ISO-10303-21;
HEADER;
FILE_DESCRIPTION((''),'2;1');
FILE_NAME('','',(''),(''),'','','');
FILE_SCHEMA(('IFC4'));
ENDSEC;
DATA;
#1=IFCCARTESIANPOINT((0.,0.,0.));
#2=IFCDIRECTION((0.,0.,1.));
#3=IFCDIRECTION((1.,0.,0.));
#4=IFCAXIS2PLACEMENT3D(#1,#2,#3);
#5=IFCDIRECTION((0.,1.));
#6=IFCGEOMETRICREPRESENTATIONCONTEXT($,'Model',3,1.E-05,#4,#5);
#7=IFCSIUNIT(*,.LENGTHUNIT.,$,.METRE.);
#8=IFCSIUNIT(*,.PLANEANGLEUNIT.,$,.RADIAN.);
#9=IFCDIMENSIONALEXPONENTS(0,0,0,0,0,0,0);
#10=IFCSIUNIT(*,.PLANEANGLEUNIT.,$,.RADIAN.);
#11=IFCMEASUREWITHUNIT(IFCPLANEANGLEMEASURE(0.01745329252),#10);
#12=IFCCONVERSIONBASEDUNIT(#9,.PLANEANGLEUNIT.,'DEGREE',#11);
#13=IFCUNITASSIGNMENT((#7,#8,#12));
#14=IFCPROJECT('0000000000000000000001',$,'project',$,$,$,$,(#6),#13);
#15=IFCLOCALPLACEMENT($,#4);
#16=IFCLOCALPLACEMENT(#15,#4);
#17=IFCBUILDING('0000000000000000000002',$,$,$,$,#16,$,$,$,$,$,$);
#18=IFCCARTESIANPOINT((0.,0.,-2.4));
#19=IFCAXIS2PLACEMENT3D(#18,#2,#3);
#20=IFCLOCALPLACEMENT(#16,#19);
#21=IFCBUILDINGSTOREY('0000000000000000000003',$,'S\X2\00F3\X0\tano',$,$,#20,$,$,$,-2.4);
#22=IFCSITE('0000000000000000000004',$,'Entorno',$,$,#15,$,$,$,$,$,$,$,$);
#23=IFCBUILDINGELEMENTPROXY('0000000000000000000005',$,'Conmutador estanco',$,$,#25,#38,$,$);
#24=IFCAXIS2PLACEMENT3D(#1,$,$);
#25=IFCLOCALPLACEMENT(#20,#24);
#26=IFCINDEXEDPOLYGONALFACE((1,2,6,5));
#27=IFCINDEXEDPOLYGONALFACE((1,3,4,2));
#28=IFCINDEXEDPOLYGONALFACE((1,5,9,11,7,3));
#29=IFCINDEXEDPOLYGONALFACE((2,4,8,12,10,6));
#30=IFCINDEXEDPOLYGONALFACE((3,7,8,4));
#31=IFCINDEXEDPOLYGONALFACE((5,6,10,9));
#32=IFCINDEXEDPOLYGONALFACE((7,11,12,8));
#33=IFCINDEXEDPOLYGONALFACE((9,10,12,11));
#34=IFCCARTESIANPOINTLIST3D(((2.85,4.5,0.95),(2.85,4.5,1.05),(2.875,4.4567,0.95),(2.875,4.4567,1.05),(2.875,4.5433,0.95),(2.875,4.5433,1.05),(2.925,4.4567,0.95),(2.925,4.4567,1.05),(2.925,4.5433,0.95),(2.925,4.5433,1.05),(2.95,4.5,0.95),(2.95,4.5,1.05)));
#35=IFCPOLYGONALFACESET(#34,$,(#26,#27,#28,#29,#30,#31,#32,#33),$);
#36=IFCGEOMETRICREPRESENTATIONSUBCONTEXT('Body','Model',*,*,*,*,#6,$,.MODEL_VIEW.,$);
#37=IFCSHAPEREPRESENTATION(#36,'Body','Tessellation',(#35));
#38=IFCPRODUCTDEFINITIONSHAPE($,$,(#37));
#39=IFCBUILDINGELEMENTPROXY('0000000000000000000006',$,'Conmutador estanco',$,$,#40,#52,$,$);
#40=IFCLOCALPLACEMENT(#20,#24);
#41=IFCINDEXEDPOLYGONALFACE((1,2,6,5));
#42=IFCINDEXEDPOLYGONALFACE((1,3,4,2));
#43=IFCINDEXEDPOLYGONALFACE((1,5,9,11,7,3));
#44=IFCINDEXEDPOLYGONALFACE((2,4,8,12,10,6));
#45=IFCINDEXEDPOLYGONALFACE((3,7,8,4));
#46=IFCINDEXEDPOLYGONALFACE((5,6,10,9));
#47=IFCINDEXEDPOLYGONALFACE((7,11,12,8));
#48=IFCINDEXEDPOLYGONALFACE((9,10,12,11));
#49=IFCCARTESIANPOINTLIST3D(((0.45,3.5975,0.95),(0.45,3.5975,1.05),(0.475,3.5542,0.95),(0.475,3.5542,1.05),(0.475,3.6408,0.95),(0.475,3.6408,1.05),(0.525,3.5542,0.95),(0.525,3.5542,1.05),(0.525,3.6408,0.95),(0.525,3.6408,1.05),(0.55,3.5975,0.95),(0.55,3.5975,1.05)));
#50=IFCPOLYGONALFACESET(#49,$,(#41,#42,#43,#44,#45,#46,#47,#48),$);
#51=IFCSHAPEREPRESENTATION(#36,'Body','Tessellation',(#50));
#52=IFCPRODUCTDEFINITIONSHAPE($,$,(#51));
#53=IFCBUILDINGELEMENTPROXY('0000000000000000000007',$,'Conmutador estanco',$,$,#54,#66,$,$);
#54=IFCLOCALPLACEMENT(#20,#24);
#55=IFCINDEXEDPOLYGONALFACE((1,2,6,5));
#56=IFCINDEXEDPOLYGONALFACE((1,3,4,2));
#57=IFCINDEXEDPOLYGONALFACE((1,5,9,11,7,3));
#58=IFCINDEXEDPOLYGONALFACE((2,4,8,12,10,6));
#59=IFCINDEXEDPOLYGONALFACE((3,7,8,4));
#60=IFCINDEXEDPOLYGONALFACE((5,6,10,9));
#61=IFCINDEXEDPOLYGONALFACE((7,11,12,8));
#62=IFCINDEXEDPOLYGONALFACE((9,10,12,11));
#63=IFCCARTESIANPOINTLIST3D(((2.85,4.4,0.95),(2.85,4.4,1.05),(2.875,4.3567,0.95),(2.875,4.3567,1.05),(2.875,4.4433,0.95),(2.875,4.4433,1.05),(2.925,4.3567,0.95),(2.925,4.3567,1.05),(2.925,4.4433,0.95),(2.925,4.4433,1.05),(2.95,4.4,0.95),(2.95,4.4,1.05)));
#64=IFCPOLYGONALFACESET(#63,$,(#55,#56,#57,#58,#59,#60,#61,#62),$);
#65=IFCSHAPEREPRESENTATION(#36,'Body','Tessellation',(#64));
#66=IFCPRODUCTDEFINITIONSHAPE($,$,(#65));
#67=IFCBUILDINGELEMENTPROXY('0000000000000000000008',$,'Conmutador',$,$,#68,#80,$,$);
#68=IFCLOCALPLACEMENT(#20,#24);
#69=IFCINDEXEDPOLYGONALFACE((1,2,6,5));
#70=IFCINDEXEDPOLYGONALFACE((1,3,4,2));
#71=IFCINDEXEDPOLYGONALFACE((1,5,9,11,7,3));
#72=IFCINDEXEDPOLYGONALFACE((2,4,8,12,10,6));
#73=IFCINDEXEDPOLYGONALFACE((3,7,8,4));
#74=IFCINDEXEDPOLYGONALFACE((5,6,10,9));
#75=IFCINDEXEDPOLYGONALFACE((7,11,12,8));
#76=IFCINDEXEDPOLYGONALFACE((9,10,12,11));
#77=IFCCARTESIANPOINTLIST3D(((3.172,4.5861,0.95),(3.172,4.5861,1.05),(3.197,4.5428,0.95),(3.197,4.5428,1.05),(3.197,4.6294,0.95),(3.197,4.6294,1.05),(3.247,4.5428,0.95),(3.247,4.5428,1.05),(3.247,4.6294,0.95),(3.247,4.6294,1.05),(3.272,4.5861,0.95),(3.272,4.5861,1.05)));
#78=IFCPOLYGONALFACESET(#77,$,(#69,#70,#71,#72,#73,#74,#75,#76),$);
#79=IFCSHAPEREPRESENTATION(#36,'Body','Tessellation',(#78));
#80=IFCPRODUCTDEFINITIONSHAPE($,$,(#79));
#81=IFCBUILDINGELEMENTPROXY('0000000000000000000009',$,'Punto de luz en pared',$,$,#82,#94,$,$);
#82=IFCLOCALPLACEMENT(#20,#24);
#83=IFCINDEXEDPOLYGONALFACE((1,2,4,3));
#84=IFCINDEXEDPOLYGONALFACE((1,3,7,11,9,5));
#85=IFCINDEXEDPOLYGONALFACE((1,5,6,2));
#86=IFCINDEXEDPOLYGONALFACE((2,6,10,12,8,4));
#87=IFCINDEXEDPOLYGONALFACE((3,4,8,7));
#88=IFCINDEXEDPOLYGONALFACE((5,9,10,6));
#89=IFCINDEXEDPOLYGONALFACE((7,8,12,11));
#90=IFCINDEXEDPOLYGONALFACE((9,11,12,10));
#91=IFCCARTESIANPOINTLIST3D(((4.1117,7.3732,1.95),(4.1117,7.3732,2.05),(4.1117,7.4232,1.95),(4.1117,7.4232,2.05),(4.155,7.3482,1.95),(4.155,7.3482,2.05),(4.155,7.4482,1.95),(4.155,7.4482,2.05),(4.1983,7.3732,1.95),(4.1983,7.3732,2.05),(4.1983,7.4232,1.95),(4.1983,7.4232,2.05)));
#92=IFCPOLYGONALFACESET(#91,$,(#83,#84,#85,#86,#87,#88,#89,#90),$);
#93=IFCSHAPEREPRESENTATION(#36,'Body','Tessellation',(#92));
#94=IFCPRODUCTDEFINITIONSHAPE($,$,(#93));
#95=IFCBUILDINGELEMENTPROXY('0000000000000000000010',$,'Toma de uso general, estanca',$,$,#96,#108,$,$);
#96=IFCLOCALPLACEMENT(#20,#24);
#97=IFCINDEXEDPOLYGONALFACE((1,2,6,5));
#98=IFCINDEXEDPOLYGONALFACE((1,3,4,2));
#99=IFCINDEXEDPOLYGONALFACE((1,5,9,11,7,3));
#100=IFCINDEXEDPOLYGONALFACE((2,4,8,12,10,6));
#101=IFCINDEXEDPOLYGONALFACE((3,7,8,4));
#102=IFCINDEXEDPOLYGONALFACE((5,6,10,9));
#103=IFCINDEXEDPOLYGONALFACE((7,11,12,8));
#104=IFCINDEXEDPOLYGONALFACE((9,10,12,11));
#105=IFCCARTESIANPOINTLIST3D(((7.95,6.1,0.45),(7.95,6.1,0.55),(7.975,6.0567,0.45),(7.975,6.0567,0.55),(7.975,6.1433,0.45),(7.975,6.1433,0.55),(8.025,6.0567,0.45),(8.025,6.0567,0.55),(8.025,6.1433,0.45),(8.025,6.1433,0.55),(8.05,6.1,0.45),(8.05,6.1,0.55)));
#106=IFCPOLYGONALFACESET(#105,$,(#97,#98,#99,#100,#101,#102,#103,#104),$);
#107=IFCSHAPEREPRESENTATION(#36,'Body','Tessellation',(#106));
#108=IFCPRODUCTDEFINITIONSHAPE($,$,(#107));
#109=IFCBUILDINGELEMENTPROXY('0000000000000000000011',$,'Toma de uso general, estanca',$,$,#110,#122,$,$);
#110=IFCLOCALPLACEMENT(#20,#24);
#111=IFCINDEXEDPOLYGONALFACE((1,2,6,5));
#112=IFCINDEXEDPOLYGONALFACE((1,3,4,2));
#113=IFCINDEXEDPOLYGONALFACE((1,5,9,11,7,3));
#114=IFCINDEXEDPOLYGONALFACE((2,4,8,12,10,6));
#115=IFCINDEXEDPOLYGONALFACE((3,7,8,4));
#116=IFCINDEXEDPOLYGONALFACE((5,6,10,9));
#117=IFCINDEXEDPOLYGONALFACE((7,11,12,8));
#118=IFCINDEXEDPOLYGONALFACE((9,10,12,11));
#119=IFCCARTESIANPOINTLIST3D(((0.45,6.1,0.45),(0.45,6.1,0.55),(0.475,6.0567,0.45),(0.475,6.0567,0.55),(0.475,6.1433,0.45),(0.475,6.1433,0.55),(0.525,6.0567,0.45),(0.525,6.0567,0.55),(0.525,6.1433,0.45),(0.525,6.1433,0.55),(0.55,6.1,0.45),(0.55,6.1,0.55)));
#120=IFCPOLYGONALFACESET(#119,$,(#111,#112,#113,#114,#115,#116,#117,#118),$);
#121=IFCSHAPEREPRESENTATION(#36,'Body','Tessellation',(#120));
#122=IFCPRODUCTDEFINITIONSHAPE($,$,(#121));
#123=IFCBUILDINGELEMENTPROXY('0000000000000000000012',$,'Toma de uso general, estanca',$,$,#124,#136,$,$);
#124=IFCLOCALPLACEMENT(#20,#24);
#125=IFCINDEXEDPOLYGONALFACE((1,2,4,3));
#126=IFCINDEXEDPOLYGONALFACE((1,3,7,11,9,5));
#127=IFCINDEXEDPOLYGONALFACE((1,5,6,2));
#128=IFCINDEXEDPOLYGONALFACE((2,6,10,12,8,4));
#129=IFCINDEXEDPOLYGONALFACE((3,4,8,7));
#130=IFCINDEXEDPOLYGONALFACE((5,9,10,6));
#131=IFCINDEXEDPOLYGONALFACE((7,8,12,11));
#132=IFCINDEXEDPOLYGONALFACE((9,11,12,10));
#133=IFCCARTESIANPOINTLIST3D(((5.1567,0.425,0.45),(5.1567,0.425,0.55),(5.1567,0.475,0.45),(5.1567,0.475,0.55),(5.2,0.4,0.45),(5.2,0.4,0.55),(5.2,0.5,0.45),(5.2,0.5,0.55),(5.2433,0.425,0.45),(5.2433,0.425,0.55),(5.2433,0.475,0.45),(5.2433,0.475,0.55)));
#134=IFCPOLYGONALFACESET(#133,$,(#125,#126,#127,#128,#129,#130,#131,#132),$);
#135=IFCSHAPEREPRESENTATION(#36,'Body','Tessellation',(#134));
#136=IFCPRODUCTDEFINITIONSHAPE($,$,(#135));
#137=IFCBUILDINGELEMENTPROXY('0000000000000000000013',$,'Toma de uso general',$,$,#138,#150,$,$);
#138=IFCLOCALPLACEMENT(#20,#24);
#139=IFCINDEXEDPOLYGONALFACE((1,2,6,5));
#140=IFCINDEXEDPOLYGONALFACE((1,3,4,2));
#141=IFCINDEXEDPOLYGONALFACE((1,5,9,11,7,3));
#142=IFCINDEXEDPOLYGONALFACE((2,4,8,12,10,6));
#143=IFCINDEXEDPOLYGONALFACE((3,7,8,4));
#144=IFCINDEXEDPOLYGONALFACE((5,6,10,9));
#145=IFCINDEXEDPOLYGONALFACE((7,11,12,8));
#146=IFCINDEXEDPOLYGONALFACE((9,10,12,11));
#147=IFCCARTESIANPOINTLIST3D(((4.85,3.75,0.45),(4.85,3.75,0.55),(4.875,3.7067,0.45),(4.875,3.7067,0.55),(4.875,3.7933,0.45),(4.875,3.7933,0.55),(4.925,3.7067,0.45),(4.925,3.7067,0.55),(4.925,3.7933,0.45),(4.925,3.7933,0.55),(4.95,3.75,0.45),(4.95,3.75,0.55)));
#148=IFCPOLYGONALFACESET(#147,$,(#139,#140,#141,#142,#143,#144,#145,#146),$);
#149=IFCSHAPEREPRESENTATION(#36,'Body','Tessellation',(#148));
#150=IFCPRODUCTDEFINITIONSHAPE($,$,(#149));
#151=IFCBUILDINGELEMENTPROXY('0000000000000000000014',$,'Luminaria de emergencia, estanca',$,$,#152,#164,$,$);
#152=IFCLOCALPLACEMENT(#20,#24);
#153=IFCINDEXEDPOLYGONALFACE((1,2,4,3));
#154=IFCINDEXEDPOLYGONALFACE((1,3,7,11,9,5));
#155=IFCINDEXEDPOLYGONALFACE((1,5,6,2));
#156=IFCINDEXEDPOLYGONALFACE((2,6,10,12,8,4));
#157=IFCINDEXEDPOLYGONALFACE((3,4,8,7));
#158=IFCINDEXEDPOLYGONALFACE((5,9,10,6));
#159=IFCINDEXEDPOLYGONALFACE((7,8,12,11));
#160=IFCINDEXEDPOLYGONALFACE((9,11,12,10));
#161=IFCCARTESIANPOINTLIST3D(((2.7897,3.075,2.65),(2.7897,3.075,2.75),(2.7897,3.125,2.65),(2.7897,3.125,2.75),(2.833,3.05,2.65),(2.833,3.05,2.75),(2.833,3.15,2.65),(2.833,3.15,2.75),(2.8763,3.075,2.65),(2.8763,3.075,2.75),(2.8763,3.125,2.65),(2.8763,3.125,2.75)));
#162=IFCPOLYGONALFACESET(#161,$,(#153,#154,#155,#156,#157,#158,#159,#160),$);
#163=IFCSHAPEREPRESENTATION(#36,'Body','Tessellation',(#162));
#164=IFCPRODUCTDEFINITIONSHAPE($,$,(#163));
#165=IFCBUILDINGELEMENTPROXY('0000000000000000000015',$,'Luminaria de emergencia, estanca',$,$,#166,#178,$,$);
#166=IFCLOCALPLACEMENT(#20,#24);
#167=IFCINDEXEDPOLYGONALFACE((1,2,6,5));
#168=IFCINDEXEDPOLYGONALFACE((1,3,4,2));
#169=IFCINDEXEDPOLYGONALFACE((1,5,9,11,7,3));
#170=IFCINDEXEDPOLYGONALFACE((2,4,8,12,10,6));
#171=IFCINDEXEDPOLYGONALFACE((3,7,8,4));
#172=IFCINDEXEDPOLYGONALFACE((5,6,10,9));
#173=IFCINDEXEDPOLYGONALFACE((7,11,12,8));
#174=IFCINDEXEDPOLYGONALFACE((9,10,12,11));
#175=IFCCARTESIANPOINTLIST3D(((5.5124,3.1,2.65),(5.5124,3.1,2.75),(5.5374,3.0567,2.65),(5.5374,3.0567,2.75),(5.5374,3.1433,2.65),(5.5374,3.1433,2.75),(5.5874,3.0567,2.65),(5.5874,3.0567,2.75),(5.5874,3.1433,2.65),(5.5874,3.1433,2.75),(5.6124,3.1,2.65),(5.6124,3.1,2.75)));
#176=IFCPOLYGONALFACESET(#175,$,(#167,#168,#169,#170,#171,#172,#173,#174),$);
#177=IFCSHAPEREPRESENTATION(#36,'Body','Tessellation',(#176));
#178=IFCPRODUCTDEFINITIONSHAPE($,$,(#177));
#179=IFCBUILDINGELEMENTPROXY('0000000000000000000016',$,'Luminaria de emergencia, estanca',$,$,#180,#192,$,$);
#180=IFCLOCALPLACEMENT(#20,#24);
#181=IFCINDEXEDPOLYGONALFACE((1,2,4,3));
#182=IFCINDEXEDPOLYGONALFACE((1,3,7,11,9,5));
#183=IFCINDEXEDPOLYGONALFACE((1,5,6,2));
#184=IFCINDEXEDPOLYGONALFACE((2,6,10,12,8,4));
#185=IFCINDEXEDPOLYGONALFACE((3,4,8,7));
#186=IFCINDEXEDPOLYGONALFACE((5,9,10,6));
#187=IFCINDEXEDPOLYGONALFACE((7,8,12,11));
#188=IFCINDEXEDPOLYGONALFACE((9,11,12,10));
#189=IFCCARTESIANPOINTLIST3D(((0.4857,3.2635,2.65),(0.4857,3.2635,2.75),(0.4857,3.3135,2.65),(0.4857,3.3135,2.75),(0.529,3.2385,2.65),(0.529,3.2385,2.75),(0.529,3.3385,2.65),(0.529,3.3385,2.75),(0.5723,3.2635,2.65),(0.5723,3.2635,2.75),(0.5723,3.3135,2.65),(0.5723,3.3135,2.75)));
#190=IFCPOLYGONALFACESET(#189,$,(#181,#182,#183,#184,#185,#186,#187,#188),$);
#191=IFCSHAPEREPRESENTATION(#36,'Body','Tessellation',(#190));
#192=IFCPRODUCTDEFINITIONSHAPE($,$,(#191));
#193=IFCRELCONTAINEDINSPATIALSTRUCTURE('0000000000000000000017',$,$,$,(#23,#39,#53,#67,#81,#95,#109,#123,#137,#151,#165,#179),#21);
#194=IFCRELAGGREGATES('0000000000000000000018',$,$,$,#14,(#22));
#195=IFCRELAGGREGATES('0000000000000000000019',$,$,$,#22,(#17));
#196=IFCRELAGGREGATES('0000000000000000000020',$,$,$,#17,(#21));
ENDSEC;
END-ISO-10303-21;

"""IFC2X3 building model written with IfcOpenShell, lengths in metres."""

from ifc_helpers import new_model, entity, si_unit, converted_unit, direction, frame, origin_with_axes, place, context, subcontext, project, spatial, polyline, outline, extrude, source, transform, mapped, element, save


model = new_model("IFC2X3")

# Units and contexts
model_context = context("Model", 3, precision=1e-05, world=origin_with_axes(), true_north=direction((0.0, 1.0)))
body_context = subcontext(model_context, "Body", "Model", "MODEL_VIEW")
ifc_project = project(units=[si_unit("LENGTHUNIT", "METRE"), si_unit("PLANEANGLEUNIT", "RADIAN"), converted_unit("PLANEANGLEUNIT", "DEGREE", entity("IfcPlaneAngleMeasure", 0.01745329252), si_unit("PLANEANGLEUNIT", "RADIAN"), dimensions=[0, 0, 0, 0, 0, 0, 0])], contexts=[model_context])

# Site, building, storey
site_placement = place(None, origin_with_axes())
site = spatial("IfcSite", under=ifc_project, at=site_placement, Name="Entorno")
building_placement = place(site_placement, origin_with_axes())
building = spatial("IfcBuilding", under=site, at=building_placement)
storey_placement = place(building_placement, frame((0.0, 0.0, -2.4), z_axis=(0.0, 0.0, 1.0), x_axis=(1.0, 0.0, 0.0)))
storey = spatial("IfcBuildingStorey", under=building, at=storey_placement, Name="Sótano", Elevation=-2.4)

# Building element proxies
shared_shape_1 = source(origin_with_axes(), body_context, "Body", "SolidModel", [
    extrude(outline(polyline([(0.05, 0.0), (0.025, 0.0433), (-0.025, 0.0433), (-0.05, 0.0), (-0.025, -0.0433), (0.025, -0.0433), (0.05, 0.0)])), frame((0.0, 0.0, -0.05), z_axis=(0.0, 0.0, 1.0), x_axis=(1.0, 0.0, 0.0)), (0.0, 0.0, 1.0), 0.1),
])
proxy_1_placement = place(storey_placement, frame((0.0, 0.0, 2.4), z_axis=(0.0, 0.0, 1.0), x_axis=(1.0, 0.0, 0.0)))
element("IfcBuildingElementProxy", 1, at=proxy_1_placement, inside=storey, Name="Conmutador estanco", context=body_context, shape_type="Brep", body=[
    mapped(shared_shape_1, transform((2.9, 4.5, -1.4), x_axis=(1.0, 0.0, 0.0), y_axis=(0.0, 1.0, 0.0), z_axis=(0.0, 0.0, 1.0))),
])
proxy_2_placement = place(storey_placement, frame((0.0, 0.0, 2.4), z_axis=(0.0, 0.0, 1.0), x_axis=(1.0, 0.0, 0.0)))
element("IfcBuildingElementProxy", 2, at=proxy_2_placement, inside=storey, Name="Conmutador estanco", context=body_context, shape_type="Brep", body=[
    mapped(shared_shape_1, transform((0.5, 3.5975, -1.4), x_axis=(1.0, 0.0, 0.0), y_axis=(0.0, 1.0, 0.0), z_axis=(0.0, 0.0, 1.0))),
])
proxy_3_placement = place(storey_placement, frame((0.0, 0.0, 2.4), z_axis=(0.0, 0.0, 1.0), x_axis=(1.0, 0.0, 0.0)))
element("IfcBuildingElementProxy", 3, at=proxy_3_placement, inside=storey, Name="Conmutador estanco", context=body_context, shape_type="Brep", body=[
    mapped(shared_shape_1, transform((2.9, 4.4, -1.4), x_axis=(1.0, 0.0, 0.0), y_axis=(0.0, 1.0, 0.0), z_axis=(0.0, 0.0, 1.0))),
])
shared_shape_2 = source(origin_with_axes(), body_context, "Body", "SolidModel", [
    extrude(outline(polyline([(0.05, 0.0), (0.025, 0.0433), (-0.025, 0.0433), (-0.05, 0.0), (-0.025, -0.0433), (0.025, -0.0433), (0.05, 0.0)])), frame((0.0, 0.0, -0.05), z_axis=(0.0, 0.0, 1.0), x_axis=(1.0, 0.0, 0.0)), (0.0, 0.0, 1.0), 0.1),
])
proxy_4_placement = place(storey_placement, frame((0.0, 0.0, 2.4), z_axis=(0.0, 0.0, 1.0), x_axis=(1.0, 0.0, 0.0)))
element("IfcBuildingElementProxy", 4, at=proxy_4_placement, inside=storey, Name="Conmutador", context=body_context, shape_type="Brep", body=[
    mapped(shared_shape_2, transform((3.222, 4.5861, -1.4), x_axis=(1.0, 0.0, 0.0), y_axis=(0.0, 1.0, 0.0), z_axis=(0.0, 0.0, 1.0))),
])
shared_shape_3 = source(origin_with_axes(), body_context, "Body", "SolidModel", [
    extrude(outline(polyline([(0.05, 0.0), (0.025, 0.0433), (-0.025, 0.0433), (-0.05, 0.0), (-0.025, -0.0433), (0.025, -0.0433), (0.05, 0.0)])), frame((0.0, 0.0, -0.05), z_axis=(0.0, 0.0, 1.0), x_axis=(1.0, 0.0, 0.0)), (0.0, 0.0, 1.0), 0.1),
])
proxy_5_placement = place(storey_placement, frame((0.0, 0.0, 2.4), z_axis=(0.0, 0.0, 1.0), x_axis=(1.0, 0.0, 0.0)))
element("IfcBuildingElementProxy", 5, at=proxy_5_placement, inside=storey, Name="Punto de luz en pared", context=body_context, shape_type="Brep", body=[
    mapped(shared_shape_3, transform((4.155, 7.3982, -0.4), x_axis=(0.0, -1.0, 0.0), y_axis=(1.0, 0.0, 0.0), z_axis=(0.0, 0.0, 1.0))),
])
shared_shape_4 = source(origin_with_axes(), body_context, "Body", "SolidModel", [
    extrude(outline(polyline([(0.05, 0.0), (0.025, 0.0433), (-0.025, 0.0433), (-0.05, 0.0), (-0.025, -0.0433), (0.025, -0.0433), (0.05, 0.0)])), frame((0.0, 0.0, -0.05), z_axis=(0.0, 0.0, 1.0), x_axis=(1.0, 0.0, 0.0)), (0.0, 0.0, 1.0), 0.1),
])
proxy_6_placement = place(storey_placement, frame((0.0, 0.0, 2.4), z_axis=(0.0, 0.0, 1.0), x_axis=(1.0, 0.0, 0.0)))
element("IfcBuildingElementProxy", 6, at=proxy_6_placement, inside=storey, Name="Toma de uso general, estanca", context=body_context, shape_type="Brep", body=[
    mapped(shared_shape_4, transform((8.0, 6.1, -1.9), x_axis=(1.0, 0.0, 0.0), y_axis=(0.0, 1.0, 0.0), z_axis=(0.0, 0.0, 1.0))),
])
proxy_7_placement = place(storey_placement, frame((0.0, 0.0, 2.4), z_axis=(0.0, 0.0, 1.0), x_axis=(1.0, 0.0, 0.0)))
element("IfcBuildingElementProxy", 7, at=proxy_7_placement, inside=storey, Name="Toma de uso general, estanca", context=body_context, shape_type="Brep", body=[
    mapped(shared_shape_4, transform((0.5, 6.1, -1.9), x_axis=(-1.0, 0.0, 0.0), y_axis=(0.0, -1.0, 0.0), z_axis=(0.0, 0.0, 1.0))),
])
proxy_8_placement = place(storey_placement, frame((0.0, 0.0, 2.4), z_axis=(0.0, 0.0, 1.0), x_axis=(1.0, 0.0, 0.0)))
element("IfcBuildingElementProxy", 8, at=proxy_8_placement, inside=storey, Name="Toma de uso general, estanca", context=body_context, shape_type="Brep", body=[
    mapped(shared_shape_4, transform((5.2, 0.45, -1.9), x_axis=(0.0, -1.0, 0.0), y_axis=(1.0, 0.0, 0.0), z_axis=(0.0, 0.0, 1.0))),
])
shared_shape_5 = source(origin_with_axes(), body_context, "Body", "SolidModel", [
    extrude(outline(polyline([(0.05, 0.0), (0.025, 0.0433), (-0.025, 0.0433), (-0.05, 0.0), (-0.025, -0.0433), (0.025, -0.0433), (0.05, 0.0)])), frame((0.0, 0.0, -0.05), z_axis=(0.0, 0.0, 1.0), x_axis=(1.0, 0.0, 0.0)), (0.0, 0.0, 1.0), 0.1),
])
proxy_9_placement = place(storey_placement, frame((0.0, 0.0, 2.4), z_axis=(0.0, 0.0, 1.0), x_axis=(1.0, 0.0, 0.0)))
element("IfcBuildingElementProxy", 9, at=proxy_9_placement, inside=storey, Name="Toma de uso general", context=body_context, shape_type="Brep", body=[
    mapped(shared_shape_5, transform((4.9, 3.75, -1.9), x_axis=(1.0, 0.0, 0.0), y_axis=(0.0, 1.0, 0.0), z_axis=(0.0, 0.0, 1.0))),
])
shared_shape_6 = source(origin_with_axes(), body_context, "Body", "SolidModel", [
    extrude(outline(polyline([(0.05, 0.0), (0.025, 0.0433), (-0.025, 0.0433), (-0.05, 0.0), (-0.025, -0.0433), (0.025, -0.0433), (0.05, 0.0)])), frame((0.0, 0.0, -0.05), z_axis=(0.0, 0.0, 1.0), x_axis=(1.0, 0.0, 0.0)), (0.0, 0.0, 1.0), 0.1),
])
proxy_10_placement = place(storey_placement, frame((0.0, 0.0, 2.4), z_axis=(0.0, 0.0, 1.0), x_axis=(1.0, 0.0, 0.0)))
element("IfcBuildingElementProxy", 10, at=proxy_10_placement, inside=storey, Name="Luminaria de emergencia, estanca", context=body_context, shape_type="Brep", body=[
    mapped(shared_shape_6, transform((2.833, 3.1, 0.3), x_axis=(0.0, 1.0, 0.0), y_axis=(-1.0, 0.0, 0.0), z_axis=(0.0, 0.0, 1.0))),
])
proxy_11_placement = place(storey_placement, frame((0.0, 0.0, 2.4), z_axis=(0.0, 0.0, 1.0), x_axis=(1.0, 0.0, 0.0)))
element("IfcBuildingElementProxy", 11, at=proxy_11_placement, inside=storey, Name="Luminaria de emergencia, estanca", context=body_context, shape_type="Brep", body=[
    mapped(shared_shape_6, transform((5.5624, 3.1, 0.3), x_axis=(-1.0, 0.0, 0.0), y_axis=(0.0, -1.0, 0.0), z_axis=(0.0, 0.0, 1.0))),
])
proxy_12_placement = place(storey_placement, frame((0.0, 0.0, 2.4), z_axis=(0.0, 0.0, 1.0), x_axis=(1.0, 0.0, 0.0)))
element("IfcBuildingElementProxy", 12, at=proxy_12_placement, inside=storey, Name="Luminaria de emergencia, estanca", context=body_context, shape_type="Brep", body=[
    mapped(shared_shape_6, transform((0.529, 3.2885, 0.3), x_axis=(0.0, 1.0, 0.0), y_axis=(-1.0, 0.0, 0.0), z_axis=(0.0, 0.0, 1.0))),
])

save(model, "model.ifc")
